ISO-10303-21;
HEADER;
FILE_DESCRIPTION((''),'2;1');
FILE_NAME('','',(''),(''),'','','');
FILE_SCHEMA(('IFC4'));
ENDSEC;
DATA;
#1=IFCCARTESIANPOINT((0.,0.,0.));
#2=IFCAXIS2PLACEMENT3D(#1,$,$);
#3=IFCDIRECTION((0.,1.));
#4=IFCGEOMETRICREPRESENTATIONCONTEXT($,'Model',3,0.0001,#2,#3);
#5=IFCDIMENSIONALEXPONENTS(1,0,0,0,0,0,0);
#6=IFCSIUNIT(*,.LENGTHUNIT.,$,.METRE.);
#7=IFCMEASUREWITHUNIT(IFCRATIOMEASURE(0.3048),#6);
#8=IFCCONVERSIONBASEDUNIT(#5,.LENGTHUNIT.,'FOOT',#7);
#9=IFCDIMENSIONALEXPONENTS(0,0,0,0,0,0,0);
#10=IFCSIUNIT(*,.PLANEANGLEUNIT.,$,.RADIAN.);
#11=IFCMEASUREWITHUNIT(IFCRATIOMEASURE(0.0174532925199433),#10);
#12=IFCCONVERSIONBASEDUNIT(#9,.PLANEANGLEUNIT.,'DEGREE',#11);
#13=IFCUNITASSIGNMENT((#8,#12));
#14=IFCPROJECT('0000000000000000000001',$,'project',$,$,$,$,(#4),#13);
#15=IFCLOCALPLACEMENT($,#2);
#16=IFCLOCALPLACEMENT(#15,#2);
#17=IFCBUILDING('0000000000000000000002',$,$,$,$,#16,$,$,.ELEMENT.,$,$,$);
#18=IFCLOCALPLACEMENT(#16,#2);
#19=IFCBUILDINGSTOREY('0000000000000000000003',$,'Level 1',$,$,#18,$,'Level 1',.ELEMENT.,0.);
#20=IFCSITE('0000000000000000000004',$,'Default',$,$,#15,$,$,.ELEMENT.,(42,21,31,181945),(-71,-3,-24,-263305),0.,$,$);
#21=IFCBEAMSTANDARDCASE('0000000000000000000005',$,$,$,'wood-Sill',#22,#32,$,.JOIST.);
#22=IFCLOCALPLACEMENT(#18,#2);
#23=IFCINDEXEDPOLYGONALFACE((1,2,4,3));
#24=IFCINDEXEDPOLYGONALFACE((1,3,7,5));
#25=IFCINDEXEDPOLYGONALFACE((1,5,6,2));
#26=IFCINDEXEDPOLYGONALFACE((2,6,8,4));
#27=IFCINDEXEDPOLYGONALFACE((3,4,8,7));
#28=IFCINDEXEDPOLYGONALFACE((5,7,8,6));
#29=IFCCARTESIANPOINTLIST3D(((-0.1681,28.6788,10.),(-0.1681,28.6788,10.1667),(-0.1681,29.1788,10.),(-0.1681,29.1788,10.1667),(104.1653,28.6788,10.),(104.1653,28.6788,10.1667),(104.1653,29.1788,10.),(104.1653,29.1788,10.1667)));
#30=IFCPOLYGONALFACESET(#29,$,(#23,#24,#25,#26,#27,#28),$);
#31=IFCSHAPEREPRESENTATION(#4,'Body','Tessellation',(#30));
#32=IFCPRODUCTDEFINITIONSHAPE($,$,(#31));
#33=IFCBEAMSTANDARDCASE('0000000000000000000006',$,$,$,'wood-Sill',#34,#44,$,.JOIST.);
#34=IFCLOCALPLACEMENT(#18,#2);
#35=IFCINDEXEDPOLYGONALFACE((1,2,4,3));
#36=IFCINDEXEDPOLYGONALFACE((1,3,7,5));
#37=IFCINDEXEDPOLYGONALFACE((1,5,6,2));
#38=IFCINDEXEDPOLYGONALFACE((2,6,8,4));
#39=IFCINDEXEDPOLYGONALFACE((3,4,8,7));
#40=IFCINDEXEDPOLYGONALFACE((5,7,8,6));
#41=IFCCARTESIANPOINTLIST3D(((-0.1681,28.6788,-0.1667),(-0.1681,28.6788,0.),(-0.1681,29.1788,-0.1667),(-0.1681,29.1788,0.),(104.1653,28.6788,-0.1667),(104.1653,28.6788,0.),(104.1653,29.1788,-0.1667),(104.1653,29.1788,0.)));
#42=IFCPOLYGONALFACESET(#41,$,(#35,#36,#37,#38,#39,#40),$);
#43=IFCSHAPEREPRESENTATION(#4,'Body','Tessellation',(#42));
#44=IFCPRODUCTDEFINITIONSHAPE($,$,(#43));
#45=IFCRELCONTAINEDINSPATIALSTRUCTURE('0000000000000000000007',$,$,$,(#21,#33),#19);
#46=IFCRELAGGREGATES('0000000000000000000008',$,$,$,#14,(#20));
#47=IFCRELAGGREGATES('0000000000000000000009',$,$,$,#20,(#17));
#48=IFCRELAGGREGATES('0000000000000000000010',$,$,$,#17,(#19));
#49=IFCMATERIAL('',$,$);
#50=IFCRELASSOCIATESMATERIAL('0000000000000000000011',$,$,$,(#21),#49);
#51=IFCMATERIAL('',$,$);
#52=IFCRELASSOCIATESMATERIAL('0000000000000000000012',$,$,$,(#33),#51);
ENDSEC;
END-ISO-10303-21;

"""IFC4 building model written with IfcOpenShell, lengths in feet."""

from ifc_helpers import new_model, entity, si_unit, converted_unit, direction, frame, origin, place, context, project, spatial, rectangle, extrude, material, element, save


model = new_model("IFC4")

# Units and contexts
model_context = context("Model", 3, precision=0.0001, world=origin(), true_north=direction((0.0, 1.0)))
ifc_project = project(units=[converted_unit("LENGTHUNIT", "FOOT", entity("IfcRatioMeasure", 0.3048), si_unit("LENGTHUNIT", "METRE"), dimensions=[1, 0, 0, 0, 0, 0, 0]), converted_unit("PLANEANGLEUNIT", "DEGREE", entity("IfcRatioMeasure", 0.0174532925199433), si_unit("PLANEANGLEUNIT", "RADIAN"), dimensions=[0, 0, 0, 0, 0, 0, 0])], contexts=[model_context])

# Site, building, storey
site_placement = place(None, origin())
site = spatial("IfcSite", under=ifc_project, at=site_placement, Name="Default", CompositionType="ELEMENT", RefLatitude=(42, 21, 31, 181945), RefLongitude=(-71, -3, -24, -263305), RefElevation=0.0)
building_placement = place(site_placement, origin())
building = spatial("IfcBuilding", under=site, at=building_placement, CompositionType="ELEMENT")
storey_placement = place(building_placement, origin())
storey = spatial("IfcBuildingStorey", under=building, at=storey_placement, Name="Level 1", LongName="Level 1", CompositionType="ELEMENT", Elevation=0.0)

# Shared definitions
placement = place(storey_placement, frame((-0.1681, 28.9288, 0.0)))

# Beams
ifc_material_1 = material(Name="")
beam_1_placement = place(placement, frame((52.1667, 0.0, 10.0), z_axis=(0.0, 0.0, 1.0), x_axis=(1.0, 0.0, 0.0)))
element("IfcBeamStandardCase", 1, at=beam_1_placement, inside=storey, material=ifc_material_1, ObjectType="wood-Sill", PredefinedType="JOIST", context=model_context, shape_type="SweptSolid", body=[
    extrude(rectangle(XDim=104.3334, YDim=0.5), origin(), (0.0, 0.0, 1.0), 0.1667),
])
ifc_material_2 = material(Name="")
beam_2_placement = place(placement, frame((52.1667, 0.0, -0.1667), z_axis=(0.0, 0.0, 1.0), x_axis=(1.0, 0.0, 0.0)))
element("IfcBeamStandardCase", 2, at=beam_2_placement, inside=storey, material=ifc_material_2, ObjectType="wood-Sill", PredefinedType="JOIST", context=model_context, shape_type="SweptSolid", body=[
    extrude(rectangle(XDim=104.3334, YDim=0.5), origin(), (0.0, 0.0, 1.0), 0.1667),
])

save(model, "model.ifc")
